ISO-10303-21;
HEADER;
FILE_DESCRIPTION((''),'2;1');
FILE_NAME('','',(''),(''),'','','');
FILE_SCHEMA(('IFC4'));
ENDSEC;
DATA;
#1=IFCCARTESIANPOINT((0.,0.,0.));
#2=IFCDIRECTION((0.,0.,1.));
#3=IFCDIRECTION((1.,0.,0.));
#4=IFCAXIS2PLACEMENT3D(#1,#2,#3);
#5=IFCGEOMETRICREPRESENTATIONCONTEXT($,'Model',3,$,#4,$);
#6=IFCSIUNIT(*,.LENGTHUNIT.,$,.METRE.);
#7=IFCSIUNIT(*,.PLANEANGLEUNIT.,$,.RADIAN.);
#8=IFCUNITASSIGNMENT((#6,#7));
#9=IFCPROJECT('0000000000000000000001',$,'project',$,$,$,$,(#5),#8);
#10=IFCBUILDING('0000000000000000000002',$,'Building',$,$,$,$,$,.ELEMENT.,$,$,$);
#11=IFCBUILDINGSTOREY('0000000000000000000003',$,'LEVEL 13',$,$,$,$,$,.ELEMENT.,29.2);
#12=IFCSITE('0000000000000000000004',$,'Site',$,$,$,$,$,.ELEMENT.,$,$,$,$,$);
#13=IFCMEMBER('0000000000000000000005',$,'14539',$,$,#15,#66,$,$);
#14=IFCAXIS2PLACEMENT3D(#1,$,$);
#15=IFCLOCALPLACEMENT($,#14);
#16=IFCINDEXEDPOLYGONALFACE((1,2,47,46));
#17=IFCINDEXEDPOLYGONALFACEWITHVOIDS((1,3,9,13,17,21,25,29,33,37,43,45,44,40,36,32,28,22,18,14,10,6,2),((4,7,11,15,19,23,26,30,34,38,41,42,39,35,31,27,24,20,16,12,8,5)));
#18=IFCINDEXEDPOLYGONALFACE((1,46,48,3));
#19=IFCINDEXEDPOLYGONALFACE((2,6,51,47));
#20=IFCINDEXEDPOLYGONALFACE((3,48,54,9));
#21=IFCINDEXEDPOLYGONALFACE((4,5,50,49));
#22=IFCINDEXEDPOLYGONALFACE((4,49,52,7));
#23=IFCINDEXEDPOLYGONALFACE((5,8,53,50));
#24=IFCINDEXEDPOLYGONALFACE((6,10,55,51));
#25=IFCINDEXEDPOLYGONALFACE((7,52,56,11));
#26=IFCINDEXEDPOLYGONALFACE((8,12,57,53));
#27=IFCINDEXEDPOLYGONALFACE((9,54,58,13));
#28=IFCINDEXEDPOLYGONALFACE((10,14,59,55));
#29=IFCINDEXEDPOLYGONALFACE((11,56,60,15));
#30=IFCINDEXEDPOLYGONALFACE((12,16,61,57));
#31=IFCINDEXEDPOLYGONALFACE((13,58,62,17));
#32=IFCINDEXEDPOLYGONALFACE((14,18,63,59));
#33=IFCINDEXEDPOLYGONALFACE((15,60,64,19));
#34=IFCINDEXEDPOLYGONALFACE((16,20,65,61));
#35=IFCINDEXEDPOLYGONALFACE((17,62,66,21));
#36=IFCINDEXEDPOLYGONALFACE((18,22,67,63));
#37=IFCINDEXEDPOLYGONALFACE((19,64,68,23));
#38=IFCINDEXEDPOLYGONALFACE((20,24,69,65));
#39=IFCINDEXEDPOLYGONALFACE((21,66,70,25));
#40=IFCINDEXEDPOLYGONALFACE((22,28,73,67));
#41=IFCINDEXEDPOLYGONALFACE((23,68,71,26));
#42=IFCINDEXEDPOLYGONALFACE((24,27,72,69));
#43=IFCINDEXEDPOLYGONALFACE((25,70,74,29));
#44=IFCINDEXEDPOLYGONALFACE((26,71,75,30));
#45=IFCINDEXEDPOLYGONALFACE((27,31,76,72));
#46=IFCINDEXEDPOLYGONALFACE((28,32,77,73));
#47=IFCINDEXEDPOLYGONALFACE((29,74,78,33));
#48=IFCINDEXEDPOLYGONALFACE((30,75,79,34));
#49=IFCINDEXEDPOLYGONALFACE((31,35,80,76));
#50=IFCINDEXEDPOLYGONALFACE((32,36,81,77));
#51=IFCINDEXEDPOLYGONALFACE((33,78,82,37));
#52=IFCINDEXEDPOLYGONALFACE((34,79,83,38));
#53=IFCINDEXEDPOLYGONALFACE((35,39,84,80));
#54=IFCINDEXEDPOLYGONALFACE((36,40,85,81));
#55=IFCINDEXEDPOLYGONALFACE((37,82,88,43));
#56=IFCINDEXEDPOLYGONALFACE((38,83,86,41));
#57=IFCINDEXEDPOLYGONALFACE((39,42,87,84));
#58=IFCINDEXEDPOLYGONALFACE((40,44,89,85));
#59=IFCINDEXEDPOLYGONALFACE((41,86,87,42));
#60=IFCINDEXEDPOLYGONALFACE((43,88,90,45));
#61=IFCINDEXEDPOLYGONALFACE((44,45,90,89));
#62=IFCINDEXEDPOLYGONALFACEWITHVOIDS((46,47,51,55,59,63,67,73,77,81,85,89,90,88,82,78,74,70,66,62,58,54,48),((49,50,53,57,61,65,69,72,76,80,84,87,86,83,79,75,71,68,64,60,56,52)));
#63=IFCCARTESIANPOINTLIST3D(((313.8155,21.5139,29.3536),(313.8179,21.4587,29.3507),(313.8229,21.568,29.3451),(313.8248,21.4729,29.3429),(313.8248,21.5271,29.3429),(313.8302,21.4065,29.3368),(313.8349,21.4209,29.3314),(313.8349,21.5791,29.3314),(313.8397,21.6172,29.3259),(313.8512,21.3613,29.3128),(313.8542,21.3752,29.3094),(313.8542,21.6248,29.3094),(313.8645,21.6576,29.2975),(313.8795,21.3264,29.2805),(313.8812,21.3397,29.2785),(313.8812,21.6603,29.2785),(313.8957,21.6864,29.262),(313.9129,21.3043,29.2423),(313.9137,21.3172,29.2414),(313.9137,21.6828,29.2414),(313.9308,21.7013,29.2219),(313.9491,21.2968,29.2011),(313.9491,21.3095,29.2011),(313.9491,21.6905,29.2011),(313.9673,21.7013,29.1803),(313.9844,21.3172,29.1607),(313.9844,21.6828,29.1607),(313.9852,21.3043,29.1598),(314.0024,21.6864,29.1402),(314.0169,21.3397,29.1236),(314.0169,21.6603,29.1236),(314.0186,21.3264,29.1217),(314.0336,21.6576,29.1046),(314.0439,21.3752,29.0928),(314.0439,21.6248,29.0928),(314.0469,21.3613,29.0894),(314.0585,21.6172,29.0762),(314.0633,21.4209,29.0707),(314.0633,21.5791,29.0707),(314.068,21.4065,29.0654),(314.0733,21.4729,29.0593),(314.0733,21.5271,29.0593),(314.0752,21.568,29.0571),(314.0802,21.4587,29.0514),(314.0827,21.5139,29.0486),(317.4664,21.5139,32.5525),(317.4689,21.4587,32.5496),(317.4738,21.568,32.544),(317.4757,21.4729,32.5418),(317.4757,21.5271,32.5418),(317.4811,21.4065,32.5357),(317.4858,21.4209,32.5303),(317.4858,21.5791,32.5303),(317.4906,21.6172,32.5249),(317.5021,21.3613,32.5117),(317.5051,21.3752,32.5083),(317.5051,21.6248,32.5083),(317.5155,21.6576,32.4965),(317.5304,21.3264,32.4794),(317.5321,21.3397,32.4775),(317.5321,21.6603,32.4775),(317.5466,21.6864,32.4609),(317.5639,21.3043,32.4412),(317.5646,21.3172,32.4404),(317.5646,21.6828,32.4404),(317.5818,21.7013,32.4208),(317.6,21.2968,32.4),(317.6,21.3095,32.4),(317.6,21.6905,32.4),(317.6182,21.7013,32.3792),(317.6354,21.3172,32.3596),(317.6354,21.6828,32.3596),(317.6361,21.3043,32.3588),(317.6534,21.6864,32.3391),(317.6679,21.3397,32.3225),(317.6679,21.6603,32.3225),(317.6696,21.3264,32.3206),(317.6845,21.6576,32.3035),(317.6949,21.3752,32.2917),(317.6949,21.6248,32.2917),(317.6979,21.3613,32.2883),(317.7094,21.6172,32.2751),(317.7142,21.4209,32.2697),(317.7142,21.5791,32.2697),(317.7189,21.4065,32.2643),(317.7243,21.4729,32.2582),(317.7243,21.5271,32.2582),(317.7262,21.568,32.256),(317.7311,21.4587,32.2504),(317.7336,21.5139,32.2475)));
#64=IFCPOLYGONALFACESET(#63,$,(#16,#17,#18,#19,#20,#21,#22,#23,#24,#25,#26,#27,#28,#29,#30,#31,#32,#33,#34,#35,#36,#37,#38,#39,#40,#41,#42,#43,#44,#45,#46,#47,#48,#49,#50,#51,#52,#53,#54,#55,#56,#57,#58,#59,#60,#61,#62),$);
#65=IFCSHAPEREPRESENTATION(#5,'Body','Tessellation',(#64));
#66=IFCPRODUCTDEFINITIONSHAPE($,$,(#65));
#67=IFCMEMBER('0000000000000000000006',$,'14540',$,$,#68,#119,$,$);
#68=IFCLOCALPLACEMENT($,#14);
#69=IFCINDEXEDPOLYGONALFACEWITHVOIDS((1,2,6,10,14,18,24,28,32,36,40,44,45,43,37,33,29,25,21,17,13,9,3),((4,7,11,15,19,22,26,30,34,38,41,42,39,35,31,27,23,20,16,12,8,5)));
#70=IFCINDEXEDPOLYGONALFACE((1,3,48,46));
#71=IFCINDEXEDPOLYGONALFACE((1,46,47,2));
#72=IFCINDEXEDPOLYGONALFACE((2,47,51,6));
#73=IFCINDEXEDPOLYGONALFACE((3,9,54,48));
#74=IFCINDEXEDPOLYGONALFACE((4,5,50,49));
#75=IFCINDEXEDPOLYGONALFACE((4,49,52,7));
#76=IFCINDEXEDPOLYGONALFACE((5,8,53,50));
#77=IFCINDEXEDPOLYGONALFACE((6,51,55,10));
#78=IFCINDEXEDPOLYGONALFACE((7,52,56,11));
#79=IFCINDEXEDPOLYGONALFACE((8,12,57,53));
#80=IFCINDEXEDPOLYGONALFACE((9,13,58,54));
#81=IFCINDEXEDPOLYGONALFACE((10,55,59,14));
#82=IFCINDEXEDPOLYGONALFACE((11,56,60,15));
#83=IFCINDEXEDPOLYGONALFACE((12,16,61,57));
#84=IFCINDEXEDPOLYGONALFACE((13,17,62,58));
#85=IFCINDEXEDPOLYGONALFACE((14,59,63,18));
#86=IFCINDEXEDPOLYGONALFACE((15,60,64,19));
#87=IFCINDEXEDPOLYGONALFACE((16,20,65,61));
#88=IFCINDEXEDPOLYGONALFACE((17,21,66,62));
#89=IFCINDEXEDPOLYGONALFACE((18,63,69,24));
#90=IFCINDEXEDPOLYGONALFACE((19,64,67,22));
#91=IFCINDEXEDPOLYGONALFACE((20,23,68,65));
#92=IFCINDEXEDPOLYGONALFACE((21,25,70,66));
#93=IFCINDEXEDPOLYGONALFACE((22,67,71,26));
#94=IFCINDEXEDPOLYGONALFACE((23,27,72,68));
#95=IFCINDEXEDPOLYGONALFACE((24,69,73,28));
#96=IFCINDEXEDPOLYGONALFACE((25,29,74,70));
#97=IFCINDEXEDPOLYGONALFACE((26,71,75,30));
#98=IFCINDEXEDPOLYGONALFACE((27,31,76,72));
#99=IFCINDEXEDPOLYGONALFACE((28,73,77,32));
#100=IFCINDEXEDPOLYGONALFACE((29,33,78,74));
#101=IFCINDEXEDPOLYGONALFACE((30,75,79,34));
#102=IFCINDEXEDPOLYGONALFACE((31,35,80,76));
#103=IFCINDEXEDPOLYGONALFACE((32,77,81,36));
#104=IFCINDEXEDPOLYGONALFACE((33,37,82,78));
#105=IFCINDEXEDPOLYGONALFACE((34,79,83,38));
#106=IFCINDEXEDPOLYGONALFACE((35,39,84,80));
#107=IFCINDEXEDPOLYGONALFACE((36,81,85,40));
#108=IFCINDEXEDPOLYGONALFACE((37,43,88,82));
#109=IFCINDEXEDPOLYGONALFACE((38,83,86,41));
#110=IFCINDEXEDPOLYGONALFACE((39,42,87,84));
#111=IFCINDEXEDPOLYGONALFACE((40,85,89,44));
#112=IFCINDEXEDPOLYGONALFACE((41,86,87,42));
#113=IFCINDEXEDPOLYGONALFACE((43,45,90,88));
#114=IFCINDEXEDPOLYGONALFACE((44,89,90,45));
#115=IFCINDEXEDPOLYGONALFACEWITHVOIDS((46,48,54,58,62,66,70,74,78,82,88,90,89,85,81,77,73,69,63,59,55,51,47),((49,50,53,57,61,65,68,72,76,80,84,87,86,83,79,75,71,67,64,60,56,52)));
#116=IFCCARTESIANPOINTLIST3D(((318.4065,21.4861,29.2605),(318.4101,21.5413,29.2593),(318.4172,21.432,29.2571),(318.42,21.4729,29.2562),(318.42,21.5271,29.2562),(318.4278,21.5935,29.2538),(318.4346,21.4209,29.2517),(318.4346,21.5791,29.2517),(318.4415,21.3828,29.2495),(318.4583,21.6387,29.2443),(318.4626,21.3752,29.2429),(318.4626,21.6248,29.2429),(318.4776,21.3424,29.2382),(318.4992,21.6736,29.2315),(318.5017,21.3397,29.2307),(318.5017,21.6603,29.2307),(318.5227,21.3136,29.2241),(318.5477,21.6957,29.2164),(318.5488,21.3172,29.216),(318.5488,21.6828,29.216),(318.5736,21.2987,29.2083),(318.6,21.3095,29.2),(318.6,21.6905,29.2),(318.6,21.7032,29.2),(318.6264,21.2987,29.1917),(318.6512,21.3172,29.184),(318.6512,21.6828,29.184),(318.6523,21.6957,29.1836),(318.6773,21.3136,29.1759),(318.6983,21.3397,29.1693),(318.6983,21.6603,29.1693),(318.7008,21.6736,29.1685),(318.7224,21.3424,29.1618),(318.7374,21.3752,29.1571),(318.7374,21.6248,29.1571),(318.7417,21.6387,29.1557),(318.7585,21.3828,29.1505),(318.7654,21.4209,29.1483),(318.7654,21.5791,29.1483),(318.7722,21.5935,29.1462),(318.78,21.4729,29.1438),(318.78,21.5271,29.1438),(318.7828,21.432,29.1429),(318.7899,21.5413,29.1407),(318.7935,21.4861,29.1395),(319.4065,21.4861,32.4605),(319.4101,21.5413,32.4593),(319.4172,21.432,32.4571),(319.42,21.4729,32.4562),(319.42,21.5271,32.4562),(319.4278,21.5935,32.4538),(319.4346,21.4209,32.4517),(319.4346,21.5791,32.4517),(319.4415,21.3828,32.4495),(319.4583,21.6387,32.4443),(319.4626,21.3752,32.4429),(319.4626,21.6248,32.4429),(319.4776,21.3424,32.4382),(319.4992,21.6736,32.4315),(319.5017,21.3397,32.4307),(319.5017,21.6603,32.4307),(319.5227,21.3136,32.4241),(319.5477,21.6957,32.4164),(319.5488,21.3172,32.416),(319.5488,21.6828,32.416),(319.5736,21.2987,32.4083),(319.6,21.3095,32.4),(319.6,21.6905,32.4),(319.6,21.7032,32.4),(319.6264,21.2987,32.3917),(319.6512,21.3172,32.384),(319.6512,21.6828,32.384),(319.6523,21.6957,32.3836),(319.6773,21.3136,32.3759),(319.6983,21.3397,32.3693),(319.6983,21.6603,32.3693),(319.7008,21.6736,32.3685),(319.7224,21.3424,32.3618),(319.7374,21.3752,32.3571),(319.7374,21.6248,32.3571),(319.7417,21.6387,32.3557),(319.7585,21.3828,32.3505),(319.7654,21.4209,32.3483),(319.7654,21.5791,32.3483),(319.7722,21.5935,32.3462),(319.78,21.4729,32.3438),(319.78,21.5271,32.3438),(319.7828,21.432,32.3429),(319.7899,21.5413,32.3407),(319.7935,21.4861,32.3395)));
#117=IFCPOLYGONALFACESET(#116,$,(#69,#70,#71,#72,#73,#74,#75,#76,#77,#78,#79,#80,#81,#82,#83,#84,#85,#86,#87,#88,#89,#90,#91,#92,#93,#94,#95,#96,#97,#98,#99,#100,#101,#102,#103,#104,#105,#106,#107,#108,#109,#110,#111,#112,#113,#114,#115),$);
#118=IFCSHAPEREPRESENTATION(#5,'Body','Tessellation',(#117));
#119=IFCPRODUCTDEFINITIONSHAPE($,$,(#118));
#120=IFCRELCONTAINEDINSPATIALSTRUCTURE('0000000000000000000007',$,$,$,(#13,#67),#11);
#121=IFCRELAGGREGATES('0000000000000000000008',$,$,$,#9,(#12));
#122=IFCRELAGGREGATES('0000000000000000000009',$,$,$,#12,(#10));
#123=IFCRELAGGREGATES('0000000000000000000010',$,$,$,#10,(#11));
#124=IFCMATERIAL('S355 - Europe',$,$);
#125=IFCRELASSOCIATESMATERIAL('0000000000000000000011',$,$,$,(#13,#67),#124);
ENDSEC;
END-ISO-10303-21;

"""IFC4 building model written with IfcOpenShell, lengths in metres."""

from ifc_helpers import new_model, si_unit, frame, origin_with_axes, origin_2d_with_axis, place, context, project, spatial, hollow_circle, extrude, material, material_profile, profile_set, profile_usage, element, save


model = new_model("IFC4")

# Units and contexts
model_context = context("Model", 3, world=origin_with_axes())
ifc_project = project(units=[si_unit("LENGTHUNIT", "METRE"), si_unit("PLANEANGLEUNIT", "RADIAN")], contexts=[model_context])

# Site, building, storey
site = spatial("IfcSite", under=ifc_project, Name="Site", CompositionType="ELEMENT")
building = spatial("IfcBuilding", under=site, Name="Building", CompositionType="ELEMENT")
storey = spatial("IfcBuildingStorey", under=building, Name="LEVEL 13", CompositionType="ELEMENT", Elevation=29.2)

# Members
ifc_material = material(Name="S355 - Europe")
ifc_material_profile_1 = material_profile(ifc_material, hollow_circle(Radius=0.2032, WallThickness=0.0127, at=origin_2d_with_axis()))
ifc_profile_set_1 = profile_set([ifc_material_profile_1])
ifc_profile_usage_1 = profile_usage(ifc_profile_set_1, cardinal=10)
member_1_placement = place(None, frame((317.6, 21.5, 32.4), z_axis=(-0.752133, 0.0, -0.659012), x_axis=(0.0, -1.0, 0.0)))
element("IfcMember", 1, at=member_1_placement, inside=storey, material=ifc_profile_usage_1, Name="14539", context=model_context, shape_type="SweptSolid", body=[
    extrude(hollow_circle(Radius=0.2032, WallThickness=0.0127, at=origin_2d_with_axis()), origin_with_axes(), (0.0, 0.0, 1.0), 4.8541),
])
ifc_material_profile_2 = material_profile(ifc_material, hollow_circle(Radius=0.2032, WallThickness=0.0127, at=origin_2d_with_axis()))
ifc_profile_set_2 = profile_set([ifc_material_profile_2])
ifc_profile_usage_2 = profile_usage(ifc_profile_set_2, cardinal=10)
member_2_placement = place(None, frame((318.6, 21.5, 29.2), z_axis=(0.298275, 0.0, 0.95448), x_axis=(0.0, 1.0, 0.0)))
element("IfcMember", 2, at=member_2_placement, inside=storey, material=ifc_profile_usage_2, Name="14540", context=model_context, shape_type="SweptSolid", body=[
    extrude(hollow_circle(Radius=0.2032, WallThickness=0.0127, at=origin_2d_with_axis()), origin_with_axes(), (0.0, 0.0, 1.0), 3.3526),
])

save(model, "model.ifc")
